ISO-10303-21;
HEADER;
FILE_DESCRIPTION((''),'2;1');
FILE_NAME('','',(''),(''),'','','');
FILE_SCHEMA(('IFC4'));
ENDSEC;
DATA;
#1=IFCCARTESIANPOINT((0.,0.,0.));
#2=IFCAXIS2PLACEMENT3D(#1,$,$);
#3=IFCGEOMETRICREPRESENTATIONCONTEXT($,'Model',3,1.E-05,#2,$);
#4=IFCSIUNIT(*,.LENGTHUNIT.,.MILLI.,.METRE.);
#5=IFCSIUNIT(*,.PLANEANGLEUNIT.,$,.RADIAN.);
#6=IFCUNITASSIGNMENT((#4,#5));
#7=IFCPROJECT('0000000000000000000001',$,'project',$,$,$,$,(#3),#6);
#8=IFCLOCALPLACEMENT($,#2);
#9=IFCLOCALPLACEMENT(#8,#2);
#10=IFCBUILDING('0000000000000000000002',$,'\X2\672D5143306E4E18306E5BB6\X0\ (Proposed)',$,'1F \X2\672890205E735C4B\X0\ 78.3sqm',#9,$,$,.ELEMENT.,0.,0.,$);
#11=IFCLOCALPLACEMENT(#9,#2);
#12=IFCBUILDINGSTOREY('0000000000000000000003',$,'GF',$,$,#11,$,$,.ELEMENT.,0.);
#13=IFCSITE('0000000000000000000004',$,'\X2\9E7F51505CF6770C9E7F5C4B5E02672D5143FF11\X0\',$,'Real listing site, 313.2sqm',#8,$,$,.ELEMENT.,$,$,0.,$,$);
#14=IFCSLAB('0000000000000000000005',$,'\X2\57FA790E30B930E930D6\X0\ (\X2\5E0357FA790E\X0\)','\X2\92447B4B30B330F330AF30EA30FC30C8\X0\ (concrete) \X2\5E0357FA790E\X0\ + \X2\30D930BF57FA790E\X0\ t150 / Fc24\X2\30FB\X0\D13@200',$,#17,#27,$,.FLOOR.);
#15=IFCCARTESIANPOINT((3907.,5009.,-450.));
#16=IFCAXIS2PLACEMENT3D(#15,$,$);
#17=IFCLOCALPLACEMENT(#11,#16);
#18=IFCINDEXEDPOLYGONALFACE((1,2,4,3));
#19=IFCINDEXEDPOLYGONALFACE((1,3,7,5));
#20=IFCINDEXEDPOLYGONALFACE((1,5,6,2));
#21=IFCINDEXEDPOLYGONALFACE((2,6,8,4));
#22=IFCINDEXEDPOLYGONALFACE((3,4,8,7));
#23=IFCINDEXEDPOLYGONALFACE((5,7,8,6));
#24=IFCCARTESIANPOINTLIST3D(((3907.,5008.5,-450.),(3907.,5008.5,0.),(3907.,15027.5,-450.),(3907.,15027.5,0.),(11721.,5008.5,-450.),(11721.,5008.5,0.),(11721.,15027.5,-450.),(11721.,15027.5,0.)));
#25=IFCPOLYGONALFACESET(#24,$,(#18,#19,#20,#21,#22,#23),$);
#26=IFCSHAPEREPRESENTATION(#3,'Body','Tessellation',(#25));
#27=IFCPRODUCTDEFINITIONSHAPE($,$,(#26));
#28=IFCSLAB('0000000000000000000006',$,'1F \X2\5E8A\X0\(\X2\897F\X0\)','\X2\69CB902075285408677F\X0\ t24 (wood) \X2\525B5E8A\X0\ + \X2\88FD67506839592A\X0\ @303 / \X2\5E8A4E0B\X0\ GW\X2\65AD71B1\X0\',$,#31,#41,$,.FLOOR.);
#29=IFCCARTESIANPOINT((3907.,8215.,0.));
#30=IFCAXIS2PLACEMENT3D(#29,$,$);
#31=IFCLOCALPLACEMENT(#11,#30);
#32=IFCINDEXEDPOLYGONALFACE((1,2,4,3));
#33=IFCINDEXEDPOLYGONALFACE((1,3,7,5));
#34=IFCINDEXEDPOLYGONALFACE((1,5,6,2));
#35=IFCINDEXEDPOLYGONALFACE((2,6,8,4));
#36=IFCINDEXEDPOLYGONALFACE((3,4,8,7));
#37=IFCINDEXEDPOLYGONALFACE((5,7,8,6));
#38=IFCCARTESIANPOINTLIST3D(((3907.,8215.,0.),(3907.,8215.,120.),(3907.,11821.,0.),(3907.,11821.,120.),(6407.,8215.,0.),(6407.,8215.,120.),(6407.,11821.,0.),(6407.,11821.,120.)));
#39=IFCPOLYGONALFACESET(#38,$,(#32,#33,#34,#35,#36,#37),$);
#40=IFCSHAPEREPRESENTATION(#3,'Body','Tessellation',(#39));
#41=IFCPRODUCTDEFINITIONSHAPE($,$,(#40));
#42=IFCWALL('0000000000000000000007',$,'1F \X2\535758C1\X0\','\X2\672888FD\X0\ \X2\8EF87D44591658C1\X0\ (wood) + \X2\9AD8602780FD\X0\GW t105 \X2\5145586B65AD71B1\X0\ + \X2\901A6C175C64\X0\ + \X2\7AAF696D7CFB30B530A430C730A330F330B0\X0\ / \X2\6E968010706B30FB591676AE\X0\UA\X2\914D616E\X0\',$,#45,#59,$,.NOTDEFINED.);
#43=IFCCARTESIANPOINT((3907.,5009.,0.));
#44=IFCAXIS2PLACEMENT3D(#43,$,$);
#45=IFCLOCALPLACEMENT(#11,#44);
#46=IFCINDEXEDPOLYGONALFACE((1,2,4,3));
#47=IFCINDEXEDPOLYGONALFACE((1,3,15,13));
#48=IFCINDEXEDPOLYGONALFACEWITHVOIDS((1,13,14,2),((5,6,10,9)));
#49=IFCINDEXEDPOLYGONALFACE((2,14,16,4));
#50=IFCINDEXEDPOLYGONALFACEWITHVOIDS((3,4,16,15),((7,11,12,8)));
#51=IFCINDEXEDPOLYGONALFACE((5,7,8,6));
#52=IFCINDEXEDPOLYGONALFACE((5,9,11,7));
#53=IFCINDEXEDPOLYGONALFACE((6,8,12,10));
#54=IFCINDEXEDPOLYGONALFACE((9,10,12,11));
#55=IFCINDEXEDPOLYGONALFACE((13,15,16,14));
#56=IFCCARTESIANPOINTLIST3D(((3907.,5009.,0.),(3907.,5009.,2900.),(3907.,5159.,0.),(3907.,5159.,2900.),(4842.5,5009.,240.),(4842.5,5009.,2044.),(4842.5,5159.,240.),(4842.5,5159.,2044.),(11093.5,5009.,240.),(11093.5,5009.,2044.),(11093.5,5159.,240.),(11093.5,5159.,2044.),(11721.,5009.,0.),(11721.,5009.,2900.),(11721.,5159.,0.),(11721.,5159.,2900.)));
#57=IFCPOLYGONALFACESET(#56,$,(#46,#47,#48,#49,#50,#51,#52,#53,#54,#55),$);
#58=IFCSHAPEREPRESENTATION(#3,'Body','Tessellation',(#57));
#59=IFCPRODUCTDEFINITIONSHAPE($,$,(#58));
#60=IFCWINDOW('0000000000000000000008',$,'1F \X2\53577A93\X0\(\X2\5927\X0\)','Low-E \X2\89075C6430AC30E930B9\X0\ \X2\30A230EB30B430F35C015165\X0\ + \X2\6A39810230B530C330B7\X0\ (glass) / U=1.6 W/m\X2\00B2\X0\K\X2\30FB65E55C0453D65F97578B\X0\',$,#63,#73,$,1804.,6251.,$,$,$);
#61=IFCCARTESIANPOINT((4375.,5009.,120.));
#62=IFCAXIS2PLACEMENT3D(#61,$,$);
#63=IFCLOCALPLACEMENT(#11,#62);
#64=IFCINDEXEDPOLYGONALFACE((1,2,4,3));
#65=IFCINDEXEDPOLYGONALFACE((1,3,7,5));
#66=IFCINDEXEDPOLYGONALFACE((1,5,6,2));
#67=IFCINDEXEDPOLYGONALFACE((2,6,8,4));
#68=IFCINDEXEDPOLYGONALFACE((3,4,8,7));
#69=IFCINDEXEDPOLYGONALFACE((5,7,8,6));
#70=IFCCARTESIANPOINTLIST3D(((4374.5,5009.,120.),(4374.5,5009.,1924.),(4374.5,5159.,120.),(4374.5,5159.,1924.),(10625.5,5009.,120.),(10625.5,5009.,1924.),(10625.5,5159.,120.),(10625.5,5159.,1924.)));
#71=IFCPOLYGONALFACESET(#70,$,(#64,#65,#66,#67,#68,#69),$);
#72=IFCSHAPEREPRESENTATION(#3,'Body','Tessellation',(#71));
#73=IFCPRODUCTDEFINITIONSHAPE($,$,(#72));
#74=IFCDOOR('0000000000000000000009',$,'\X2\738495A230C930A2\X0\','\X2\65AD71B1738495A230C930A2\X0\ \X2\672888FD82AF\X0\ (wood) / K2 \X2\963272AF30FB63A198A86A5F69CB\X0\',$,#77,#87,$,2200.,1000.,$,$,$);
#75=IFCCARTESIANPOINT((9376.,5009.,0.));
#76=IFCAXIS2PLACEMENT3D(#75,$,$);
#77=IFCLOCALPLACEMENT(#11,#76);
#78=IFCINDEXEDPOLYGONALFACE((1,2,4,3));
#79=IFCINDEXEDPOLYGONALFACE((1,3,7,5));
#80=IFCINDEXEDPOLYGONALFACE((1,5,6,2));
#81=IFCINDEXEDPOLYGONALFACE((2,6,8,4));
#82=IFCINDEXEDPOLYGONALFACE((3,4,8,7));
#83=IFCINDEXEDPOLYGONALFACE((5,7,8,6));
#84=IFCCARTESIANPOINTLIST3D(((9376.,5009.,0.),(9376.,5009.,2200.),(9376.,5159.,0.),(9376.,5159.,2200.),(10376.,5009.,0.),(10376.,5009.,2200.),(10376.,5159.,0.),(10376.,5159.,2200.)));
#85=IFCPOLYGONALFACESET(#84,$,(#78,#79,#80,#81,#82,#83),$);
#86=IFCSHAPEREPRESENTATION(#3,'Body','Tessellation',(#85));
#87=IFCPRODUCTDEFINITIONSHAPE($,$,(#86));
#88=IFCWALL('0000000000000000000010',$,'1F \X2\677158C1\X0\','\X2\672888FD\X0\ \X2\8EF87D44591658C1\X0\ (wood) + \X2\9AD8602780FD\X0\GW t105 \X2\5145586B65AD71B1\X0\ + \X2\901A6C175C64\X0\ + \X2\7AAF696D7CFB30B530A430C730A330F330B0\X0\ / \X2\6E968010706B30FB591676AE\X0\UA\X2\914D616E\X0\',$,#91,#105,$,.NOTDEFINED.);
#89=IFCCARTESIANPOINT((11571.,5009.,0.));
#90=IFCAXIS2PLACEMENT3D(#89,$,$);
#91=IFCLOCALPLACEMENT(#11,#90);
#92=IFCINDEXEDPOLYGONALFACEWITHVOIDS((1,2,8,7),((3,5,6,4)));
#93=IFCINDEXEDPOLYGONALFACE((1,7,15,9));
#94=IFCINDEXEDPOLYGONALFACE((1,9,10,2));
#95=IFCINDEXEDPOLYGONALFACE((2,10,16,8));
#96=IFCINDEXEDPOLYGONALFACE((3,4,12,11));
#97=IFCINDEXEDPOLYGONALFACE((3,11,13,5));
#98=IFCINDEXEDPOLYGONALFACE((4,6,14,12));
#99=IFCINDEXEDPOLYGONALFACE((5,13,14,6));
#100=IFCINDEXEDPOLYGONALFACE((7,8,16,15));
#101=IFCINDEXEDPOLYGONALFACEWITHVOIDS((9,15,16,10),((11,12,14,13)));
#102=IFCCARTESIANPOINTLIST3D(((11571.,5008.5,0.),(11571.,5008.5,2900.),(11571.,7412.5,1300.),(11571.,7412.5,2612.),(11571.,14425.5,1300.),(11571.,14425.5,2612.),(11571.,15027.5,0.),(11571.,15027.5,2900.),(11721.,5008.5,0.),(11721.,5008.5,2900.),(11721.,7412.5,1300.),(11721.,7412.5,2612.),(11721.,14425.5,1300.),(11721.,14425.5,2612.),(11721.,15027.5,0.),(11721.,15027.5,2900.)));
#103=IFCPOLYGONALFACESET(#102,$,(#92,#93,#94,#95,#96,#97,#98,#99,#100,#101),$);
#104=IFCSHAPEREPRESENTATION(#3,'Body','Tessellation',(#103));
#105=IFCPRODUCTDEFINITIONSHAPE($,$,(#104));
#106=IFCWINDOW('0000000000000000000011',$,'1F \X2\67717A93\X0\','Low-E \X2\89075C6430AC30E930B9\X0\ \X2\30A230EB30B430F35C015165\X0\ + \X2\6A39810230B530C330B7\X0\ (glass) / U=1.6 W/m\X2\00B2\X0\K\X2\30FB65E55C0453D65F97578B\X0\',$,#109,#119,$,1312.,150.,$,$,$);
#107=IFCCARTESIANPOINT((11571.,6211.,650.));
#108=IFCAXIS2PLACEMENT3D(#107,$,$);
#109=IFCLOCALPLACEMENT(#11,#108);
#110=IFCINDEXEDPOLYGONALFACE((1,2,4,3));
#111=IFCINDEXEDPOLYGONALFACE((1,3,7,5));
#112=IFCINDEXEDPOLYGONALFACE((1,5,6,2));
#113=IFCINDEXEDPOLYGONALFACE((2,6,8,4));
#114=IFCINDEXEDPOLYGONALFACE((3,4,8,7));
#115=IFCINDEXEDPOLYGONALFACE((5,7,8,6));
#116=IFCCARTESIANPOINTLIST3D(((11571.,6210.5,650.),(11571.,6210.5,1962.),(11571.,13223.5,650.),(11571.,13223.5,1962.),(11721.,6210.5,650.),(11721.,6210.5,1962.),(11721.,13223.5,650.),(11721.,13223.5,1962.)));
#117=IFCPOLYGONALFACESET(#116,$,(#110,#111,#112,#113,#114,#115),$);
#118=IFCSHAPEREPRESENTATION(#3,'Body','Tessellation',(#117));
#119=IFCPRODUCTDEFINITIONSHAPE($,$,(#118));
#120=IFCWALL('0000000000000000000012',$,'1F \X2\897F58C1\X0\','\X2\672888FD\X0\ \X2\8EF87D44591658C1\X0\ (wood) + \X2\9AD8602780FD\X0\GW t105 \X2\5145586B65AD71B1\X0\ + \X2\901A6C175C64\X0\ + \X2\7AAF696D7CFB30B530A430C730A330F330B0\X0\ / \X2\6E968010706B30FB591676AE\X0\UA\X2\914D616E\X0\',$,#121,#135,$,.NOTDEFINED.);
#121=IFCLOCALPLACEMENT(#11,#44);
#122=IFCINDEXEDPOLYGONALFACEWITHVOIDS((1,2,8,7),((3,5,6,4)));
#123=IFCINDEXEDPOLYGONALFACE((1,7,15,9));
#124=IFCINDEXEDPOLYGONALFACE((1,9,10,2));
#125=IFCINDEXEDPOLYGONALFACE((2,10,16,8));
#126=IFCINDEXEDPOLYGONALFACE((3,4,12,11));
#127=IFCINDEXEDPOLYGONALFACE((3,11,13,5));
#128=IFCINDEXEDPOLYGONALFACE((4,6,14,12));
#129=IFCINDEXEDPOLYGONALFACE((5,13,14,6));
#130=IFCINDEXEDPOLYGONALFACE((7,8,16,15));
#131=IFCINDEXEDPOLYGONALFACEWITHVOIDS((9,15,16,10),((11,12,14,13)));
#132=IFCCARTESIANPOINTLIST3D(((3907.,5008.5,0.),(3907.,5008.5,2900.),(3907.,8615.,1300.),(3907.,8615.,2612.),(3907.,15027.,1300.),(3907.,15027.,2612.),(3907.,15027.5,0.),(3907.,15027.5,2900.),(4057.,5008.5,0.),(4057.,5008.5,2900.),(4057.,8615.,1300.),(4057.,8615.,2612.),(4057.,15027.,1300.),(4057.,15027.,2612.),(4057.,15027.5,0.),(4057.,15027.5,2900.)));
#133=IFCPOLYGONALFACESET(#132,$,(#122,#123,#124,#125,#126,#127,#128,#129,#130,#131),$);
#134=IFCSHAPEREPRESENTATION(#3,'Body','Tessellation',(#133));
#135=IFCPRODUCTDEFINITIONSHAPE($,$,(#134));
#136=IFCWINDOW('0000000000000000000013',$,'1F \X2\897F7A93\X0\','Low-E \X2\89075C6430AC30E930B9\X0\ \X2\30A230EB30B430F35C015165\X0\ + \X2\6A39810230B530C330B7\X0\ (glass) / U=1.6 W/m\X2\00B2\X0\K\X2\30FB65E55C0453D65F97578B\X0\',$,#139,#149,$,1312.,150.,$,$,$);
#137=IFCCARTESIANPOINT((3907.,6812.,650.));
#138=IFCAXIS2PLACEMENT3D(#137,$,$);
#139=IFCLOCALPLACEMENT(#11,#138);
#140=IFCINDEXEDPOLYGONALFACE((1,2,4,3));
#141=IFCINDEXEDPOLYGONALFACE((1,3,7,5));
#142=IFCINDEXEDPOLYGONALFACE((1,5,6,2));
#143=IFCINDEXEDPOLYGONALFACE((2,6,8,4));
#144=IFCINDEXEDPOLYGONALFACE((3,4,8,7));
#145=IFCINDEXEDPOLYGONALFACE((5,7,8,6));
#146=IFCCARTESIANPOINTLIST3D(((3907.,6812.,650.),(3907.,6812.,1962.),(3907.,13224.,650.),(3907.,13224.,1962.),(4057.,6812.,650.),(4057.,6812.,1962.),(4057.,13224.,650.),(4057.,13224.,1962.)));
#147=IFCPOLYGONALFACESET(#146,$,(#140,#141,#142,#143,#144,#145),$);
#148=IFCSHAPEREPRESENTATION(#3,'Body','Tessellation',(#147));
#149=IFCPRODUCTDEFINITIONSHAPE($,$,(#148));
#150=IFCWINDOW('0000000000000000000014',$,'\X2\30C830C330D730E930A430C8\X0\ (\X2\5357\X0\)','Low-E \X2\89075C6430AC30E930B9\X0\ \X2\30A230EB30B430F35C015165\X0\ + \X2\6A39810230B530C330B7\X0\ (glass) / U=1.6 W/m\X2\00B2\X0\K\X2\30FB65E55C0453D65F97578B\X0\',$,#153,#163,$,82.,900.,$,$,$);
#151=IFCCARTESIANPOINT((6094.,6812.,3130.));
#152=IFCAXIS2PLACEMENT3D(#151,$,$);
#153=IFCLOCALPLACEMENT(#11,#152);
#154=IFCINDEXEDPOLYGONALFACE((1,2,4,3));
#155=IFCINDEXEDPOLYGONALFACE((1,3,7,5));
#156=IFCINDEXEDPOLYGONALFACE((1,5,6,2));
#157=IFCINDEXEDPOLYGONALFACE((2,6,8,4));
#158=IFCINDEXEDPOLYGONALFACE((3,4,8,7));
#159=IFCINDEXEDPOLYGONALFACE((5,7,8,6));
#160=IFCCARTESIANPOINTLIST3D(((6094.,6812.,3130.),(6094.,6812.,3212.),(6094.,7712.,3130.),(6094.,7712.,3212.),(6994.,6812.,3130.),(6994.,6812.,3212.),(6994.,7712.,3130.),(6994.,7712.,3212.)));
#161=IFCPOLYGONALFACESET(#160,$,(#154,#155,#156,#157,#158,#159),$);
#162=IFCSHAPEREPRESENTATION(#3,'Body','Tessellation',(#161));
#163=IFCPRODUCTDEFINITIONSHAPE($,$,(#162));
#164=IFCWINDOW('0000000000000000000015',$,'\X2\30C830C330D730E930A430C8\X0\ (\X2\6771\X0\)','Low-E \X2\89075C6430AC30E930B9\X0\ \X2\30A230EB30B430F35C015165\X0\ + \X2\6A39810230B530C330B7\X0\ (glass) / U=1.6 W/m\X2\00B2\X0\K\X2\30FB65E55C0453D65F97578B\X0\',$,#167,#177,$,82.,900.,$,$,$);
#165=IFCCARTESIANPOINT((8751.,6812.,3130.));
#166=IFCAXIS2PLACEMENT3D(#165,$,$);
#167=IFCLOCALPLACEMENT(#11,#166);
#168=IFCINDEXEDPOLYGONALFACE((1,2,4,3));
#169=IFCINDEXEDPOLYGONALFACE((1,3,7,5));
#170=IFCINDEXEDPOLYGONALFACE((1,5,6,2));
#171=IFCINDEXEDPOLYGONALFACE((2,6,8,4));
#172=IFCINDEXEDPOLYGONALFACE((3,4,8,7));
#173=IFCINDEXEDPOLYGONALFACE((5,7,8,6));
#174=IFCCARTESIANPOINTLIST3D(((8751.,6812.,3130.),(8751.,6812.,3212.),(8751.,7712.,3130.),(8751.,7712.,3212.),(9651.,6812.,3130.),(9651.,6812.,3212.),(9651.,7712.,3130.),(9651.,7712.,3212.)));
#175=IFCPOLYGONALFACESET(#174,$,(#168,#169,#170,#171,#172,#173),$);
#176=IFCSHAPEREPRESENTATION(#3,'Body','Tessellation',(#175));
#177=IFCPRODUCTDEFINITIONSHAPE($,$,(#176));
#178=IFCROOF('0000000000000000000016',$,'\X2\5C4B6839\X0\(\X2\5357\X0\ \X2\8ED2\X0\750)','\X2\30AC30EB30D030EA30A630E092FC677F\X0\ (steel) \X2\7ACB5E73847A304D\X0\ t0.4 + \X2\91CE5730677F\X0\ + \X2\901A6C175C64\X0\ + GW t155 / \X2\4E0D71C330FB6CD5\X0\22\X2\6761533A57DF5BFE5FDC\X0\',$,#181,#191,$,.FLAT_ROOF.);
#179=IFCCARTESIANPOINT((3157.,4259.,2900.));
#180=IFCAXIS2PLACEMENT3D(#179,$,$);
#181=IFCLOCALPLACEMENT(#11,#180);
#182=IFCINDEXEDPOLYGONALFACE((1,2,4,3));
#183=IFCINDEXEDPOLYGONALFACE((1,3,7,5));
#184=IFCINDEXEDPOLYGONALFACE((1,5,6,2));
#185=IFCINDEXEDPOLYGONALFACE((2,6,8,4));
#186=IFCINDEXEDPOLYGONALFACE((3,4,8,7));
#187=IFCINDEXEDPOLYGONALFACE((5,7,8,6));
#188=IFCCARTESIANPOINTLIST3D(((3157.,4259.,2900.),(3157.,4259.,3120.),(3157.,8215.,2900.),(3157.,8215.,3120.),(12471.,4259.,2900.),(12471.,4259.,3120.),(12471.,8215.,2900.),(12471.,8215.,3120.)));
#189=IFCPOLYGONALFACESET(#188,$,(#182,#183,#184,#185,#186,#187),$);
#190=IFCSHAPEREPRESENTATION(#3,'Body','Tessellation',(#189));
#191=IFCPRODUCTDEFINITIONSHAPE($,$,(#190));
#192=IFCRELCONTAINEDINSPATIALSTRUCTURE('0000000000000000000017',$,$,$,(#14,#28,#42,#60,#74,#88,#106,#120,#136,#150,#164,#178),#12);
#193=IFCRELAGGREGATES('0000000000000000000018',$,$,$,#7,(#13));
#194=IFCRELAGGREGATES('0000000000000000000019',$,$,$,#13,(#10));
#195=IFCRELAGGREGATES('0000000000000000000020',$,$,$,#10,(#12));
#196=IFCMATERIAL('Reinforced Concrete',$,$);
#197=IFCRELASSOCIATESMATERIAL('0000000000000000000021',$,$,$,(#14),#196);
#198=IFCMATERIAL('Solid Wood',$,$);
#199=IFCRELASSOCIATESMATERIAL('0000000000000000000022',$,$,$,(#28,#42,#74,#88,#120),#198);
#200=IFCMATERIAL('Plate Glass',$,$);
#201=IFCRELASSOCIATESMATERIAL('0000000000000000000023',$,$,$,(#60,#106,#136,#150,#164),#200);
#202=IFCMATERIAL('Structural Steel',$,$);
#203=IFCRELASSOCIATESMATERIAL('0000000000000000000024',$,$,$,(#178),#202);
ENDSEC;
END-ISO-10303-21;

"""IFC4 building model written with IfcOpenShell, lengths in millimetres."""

from ifc_helpers import new_model, si_unit, frame, frame_2d, origin, place, context, project, spatial, rectangle, extrude, material, element, fill, save


model = new_model("IFC4")

# Units and contexts
model_context = context("Model", 3, precision=1e-05, world=origin())
ifc_project = project(units=[si_unit("LENGTHUNIT", "METRE", prefix="MILLI"), si_unit("PLANEANGLEUNIT", "RADIAN")], contexts=[model_context])

# Site, building, storey
site_placement = place(None, origin())
site = spatial("IfcSite", under=ifc_project, at=site_placement, Name="鹿児島県鹿屋市札元１", ObjectType="Real listing site, 313.2sqm", CompositionType="ELEMENT", RefElevation=0.0)
building_placement = place(site_placement, origin())
building = spatial("IfcBuilding", under=site, at=building_placement, Name="札元の丘の家 (Proposed)", ObjectType="1F 木造平屋 78.3sqm", CompositionType="ELEMENT", ElevationOfRefHeight=0.0, ElevationOfTerrain=0.0)
storey_placement = place(building_placement, origin())
storey = spatial("IfcBuildingStorey", under=building, at=storey_placement, Name="GF", CompositionType="ELEMENT", Elevation=0.0)

# Slabs
ifc_material_1 = material(Name="Reinforced Concrete")
slab_1_placement = place(storey_placement, frame((3907.0, 5009.0, -450.0)))
element("IfcSlab", 1, at=slab_1_placement, inside=storey, material=ifc_material_1, Name="基礎スラブ (布基礎)", Description="鉄筋コンクリート (concrete) 布基礎 + ベタ基礎 t150 / Fc24・D13@200", PredefinedType="FLOOR", context=model_context, shape_type="SweptSolid", body=[
    extrude(rectangle(XDim=7814.0, YDim=10019.0, at=frame_2d((3907.0, 5009.0))), frame((3907.0, 5009.0, -450.0)), (0.0, 0.0, 1.0), 450.0),
])
ifc_material_2 = material(Name="Solid Wood")
slab_2_placement = place(storey_placement, frame((3907.0, 8215.0, 0.0)))
element("IfcSlab", 2, at=slab_2_placement, inside=storey, material=ifc_material_2, Name="1F 床(西)", Description="構造用合板 t24 (wood) 剛床 + 製材根太 @303 / 床下 GW断熱", PredefinedType="FLOOR", context=model_context, shape_type="SweptSolid", body=[
    extrude(rectangle(XDim=2500.0, YDim=3606.0, at=frame_2d((1250.0, 1803.0))), frame((3907.0, 8215.0, 0.0)), (0.0, 0.0, 1.0), 120.0),
])

# Wall, openings, window, door
wall_1_placement = place(storey_placement, frame((3907.0, 5009.0, 0.0)))
wall_1 = element("IfcWall", 3, at=wall_1_placement, inside=storey, material=ifc_material_2, Name="1F 南壁", Description="木製 軸組外壁 (wood) + 高性能GW t105 充填断熱 + 通気層 + 窯業系サイディング / 準耐火・外皮UA配慮", PredefinedType="NOTDEFINED", context=model_context, shape_type="SweptSolid", body=[
    extrude(rectangle(XDim=7814.0, YDim=150.0, at=frame_2d((3907.0, 75.0))), frame((3907.0, 5009.0, 0.0)), (0.0, 0.0, 1.0), 2900.0),
])
opening_1_placement = place(storey_placement, frame((4375.0, 5009.0, 120.0)))
opening_1 = element("IfcOpeningElement", 4, at=opening_1_placement, cuts=wall_1, PredefinedType="NOTDEFINED", context=model_context, shape_type="SweptSolid", body=[
    extrude(rectangle(XDim=6251.0, YDim=150.0, at=frame_2d((3125.0, 75.0))), frame((4375.0, 5009.0, 120.0)), (0.0, 0.0, 1.0), 1804.0),
])
opening_2_placement = place(storey_placement, frame((9376.0, 5009.0, 0.0)))
opening_2 = element("IfcOpeningElement", 5, at=opening_2_placement, cuts=wall_1, PredefinedType="NOTDEFINED", context=model_context, shape_type="SweptSolid", body=[
    extrude(rectangle(XDim=1000.0, YDim=150.0, at=frame_2d((500.0, 75.0))), frame((9376.0, 5009.0, 0.0)), (0.0, 0.0, 1.0), 2200.0),
])
ifc_material_3 = material(Name="Plate Glass")
window_1_placement = place(storey_placement, frame((4375.0, 5009.0, 120.0)))
window_1 = element("IfcWindow", 6, at=window_1_placement, inside=storey, material=ifc_material_3, Name="1F 南窓(大)", Description="Low-E 複層ガラス アルゴン封入 + 樹脂サッシ (glass) / U=1.6 W/m²K・日射取得型", OverallHeight=1804.0, OverallWidth=6251.0, context=model_context, shape_type="SweptSolid", body=[
    extrude(rectangle(XDim=6251.0, YDim=150.0, at=frame_2d((3125.0, 75.0))), frame((4375.0, 5009.0, 120.0)), (0.0, 0.0, 1.0), 1804.0),
])
fill(opening_1, window_1)
door_placement = place(storey_placement, frame((9376.0, 5009.0, 0.0)))
door = element("IfcDoor", 7, at=door_placement, inside=storey, material=ifc_material_2, Name="玄関ドア", Description="断熱玄関ドア 木製芯 (wood) / K2 防犯・採風機構", OverallHeight=2200.0, OverallWidth=1000.0, context=model_context, shape_type="SweptSolid", body=[
    extrude(rectangle(XDim=1000.0, YDim=150.0, at=frame_2d((500.0, 75.0))), frame((9376.0, 5009.0, 0.0)), (0.0, 0.0, 1.0), 2200.0),
])
fill(opening_2, door)

# Walls, openings, windows
wall_2_placement = place(storey_placement, frame((11571.0, 5009.0, 0.0)))
wall_2 = element("IfcWall", 8, at=wall_2_placement, inside=storey, material=ifc_material_2, Name="1F 東壁", Description="木製 軸組外壁 (wood) + 高性能GW t105 充填断熱 + 通気層 + 窯業系サイディング / 準耐火・外皮UA配慮", PredefinedType="NOTDEFINED", context=model_context, shape_type="SweptSolid", body=[
    extrude(rectangle(XDim=150.0, YDim=10019.0, at=frame_2d((75.0, 5009.0))), frame((11571.0, 5009.0, 0.0)), (0.0, 0.0, 1.0), 2900.0),
])
opening_3_placement = place(storey_placement, frame((11571.0, 6211.0, 650.0)))
opening_3 = element("IfcOpeningElement", 9, at=opening_3_placement, cuts=wall_2, PredefinedType="NOTDEFINED", context=model_context, shape_type="SweptSolid", body=[
    extrude(rectangle(XDim=150.0, YDim=7013.0, at=frame_2d((75.0, 3506.0))), frame((11571.0, 6211.0, 650.0)), (0.0, 0.0, 1.0), 1312.0),
])
window_2_placement = place(storey_placement, frame((11571.0, 6211.0, 650.0)))
window_2 = element("IfcWindow", 10, at=window_2_placement, inside=storey, material=ifc_material_3, Name="1F 東窓", Description="Low-E 複層ガラス アルゴン封入 + 樹脂サッシ (glass) / U=1.6 W/m²K・日射取得型", OverallHeight=1312.0, OverallWidth=150.0, context=model_context, shape_type="SweptSolid", body=[
    extrude(rectangle(XDim=150.0, YDim=7013.0, at=frame_2d((75.0, 3506.0))), frame((11571.0, 6211.0, 650.0)), (0.0, 0.0, 1.0), 1312.0),
])
fill(opening_3, window_2)
wall_3_placement = place(storey_placement, frame((3907.0, 5009.0, 0.0)))
wall_3 = element("IfcWall", 11, at=wall_3_placement, inside=storey, material=ifc_material_2, Name="1F 西壁", Description="木製 軸組外壁 (wood) + 高性能GW t105 充填断熱 + 通気層 + 窯業系サイディング / 準耐火・外皮UA配慮", PredefinedType="NOTDEFINED", context=model_context, shape_type="SweptSolid", body=[
    extrude(rectangle(XDim=150.0, YDim=10019.0, at=frame_2d((75.0, 5009.0))), frame((3907.0, 5009.0, 0.0)), (0.0, 0.0, 1.0), 2900.0),
])
opening_4_placement = place(storey_placement, frame((3907.0, 6812.0, 650.0)))
opening_4 = element("IfcOpeningElement", 12, at=opening_4_placement, cuts=wall_3, PredefinedType="NOTDEFINED", context=model_context, shape_type="SweptSolid", body=[
    extrude(rectangle(XDim=150.0, YDim=6412.0, at=frame_2d((75.0, 3206.0))), frame((3907.0, 6812.0, 650.0)), (0.0, 0.0, 1.0), 1312.0),
])
window_3_placement = place(storey_placement, frame((3907.0, 6812.0, 650.0)))
window_3 = element("IfcWindow", 13, at=window_3_placement, inside=storey, material=ifc_material_3, Name="1F 西窓", Description="Low-E 複層ガラス アルゴン封入 + 樹脂サッシ (glass) / U=1.6 W/m²K・日射取得型", OverallHeight=1312.0, OverallWidth=150.0, context=model_context, shape_type="SweptSolid", body=[
    extrude(rectangle(XDim=150.0, YDim=6412.0, at=frame_2d((75.0, 3206.0))), frame((3907.0, 6812.0, 650.0)), (0.0, 0.0, 1.0), 1312.0),
])
fill(opening_4, window_3)

# Windows
window_4_placement = place(storey_placement, frame((6094.0, 6812.0, 3130.0)))
element("IfcWindow", 14, at=window_4_placement, inside=storey, material=ifc_material_3, Name="トップライト (南)", Description="Low-E 複層ガラス アルゴン封入 + 樹脂サッシ (glass) / U=1.6 W/m²K・日射取得型", OverallHeight=82.0, OverallWidth=900.0, context=model_context, shape_type="SweptSolid", body=[
    extrude(rectangle(XDim=900.0, YDim=900.0, at=frame_2d((450.0, 450.0))), frame((6094.0, 6812.0, 3130.0)), (0.0, 0.0, 1.0), 82.0),
])
window_5_placement = place(storey_placement, frame((8751.0, 6812.0, 3130.0)))
element("IfcWindow", 15, at=window_5_placement, inside=storey, material=ifc_material_3, Name="トップライト (東)", Description="Low-E 複層ガラス アルゴン封入 + 樹脂サッシ (glass) / U=1.6 W/m²K・日射取得型", OverallHeight=82.0, OverallWidth=900.0, context=model_context, shape_type="SweptSolid", body=[
    extrude(rectangle(XDim=900.0, YDim=900.0, at=frame_2d((450.0, 450.0))), frame((8751.0, 6812.0, 3130.0)), (0.0, 0.0, 1.0), 82.0),
])

# Roof
ifc_material_4 = material(Name="Structural Steel")
roof_placement = place(storey_placement, frame((3157.0, 4259.0, 2900.0)))
element("IfcRoof", 16, at=roof_placement, inside=storey, material=ifc_material_4, Name="屋根(南 軒750)", Description="ガルバリウム鋼板 (steel) 立平葺き t0.4 + 野地板 + 通気層 + GW t155 / 不燃・法22条区域対応", PredefinedType="FLAT_ROOF", context=model_context, shape_type="SweptSolid", body=[
    extrude(rectangle(XDim=9314.0, YDim=3956.0, at=frame_2d((4657.0, 1978.0))), frame((3157.0, 4259.0, 2900.0)), (0.0, 0.0, 1.0), 220.0),
])

save(model, "model.ifc")
